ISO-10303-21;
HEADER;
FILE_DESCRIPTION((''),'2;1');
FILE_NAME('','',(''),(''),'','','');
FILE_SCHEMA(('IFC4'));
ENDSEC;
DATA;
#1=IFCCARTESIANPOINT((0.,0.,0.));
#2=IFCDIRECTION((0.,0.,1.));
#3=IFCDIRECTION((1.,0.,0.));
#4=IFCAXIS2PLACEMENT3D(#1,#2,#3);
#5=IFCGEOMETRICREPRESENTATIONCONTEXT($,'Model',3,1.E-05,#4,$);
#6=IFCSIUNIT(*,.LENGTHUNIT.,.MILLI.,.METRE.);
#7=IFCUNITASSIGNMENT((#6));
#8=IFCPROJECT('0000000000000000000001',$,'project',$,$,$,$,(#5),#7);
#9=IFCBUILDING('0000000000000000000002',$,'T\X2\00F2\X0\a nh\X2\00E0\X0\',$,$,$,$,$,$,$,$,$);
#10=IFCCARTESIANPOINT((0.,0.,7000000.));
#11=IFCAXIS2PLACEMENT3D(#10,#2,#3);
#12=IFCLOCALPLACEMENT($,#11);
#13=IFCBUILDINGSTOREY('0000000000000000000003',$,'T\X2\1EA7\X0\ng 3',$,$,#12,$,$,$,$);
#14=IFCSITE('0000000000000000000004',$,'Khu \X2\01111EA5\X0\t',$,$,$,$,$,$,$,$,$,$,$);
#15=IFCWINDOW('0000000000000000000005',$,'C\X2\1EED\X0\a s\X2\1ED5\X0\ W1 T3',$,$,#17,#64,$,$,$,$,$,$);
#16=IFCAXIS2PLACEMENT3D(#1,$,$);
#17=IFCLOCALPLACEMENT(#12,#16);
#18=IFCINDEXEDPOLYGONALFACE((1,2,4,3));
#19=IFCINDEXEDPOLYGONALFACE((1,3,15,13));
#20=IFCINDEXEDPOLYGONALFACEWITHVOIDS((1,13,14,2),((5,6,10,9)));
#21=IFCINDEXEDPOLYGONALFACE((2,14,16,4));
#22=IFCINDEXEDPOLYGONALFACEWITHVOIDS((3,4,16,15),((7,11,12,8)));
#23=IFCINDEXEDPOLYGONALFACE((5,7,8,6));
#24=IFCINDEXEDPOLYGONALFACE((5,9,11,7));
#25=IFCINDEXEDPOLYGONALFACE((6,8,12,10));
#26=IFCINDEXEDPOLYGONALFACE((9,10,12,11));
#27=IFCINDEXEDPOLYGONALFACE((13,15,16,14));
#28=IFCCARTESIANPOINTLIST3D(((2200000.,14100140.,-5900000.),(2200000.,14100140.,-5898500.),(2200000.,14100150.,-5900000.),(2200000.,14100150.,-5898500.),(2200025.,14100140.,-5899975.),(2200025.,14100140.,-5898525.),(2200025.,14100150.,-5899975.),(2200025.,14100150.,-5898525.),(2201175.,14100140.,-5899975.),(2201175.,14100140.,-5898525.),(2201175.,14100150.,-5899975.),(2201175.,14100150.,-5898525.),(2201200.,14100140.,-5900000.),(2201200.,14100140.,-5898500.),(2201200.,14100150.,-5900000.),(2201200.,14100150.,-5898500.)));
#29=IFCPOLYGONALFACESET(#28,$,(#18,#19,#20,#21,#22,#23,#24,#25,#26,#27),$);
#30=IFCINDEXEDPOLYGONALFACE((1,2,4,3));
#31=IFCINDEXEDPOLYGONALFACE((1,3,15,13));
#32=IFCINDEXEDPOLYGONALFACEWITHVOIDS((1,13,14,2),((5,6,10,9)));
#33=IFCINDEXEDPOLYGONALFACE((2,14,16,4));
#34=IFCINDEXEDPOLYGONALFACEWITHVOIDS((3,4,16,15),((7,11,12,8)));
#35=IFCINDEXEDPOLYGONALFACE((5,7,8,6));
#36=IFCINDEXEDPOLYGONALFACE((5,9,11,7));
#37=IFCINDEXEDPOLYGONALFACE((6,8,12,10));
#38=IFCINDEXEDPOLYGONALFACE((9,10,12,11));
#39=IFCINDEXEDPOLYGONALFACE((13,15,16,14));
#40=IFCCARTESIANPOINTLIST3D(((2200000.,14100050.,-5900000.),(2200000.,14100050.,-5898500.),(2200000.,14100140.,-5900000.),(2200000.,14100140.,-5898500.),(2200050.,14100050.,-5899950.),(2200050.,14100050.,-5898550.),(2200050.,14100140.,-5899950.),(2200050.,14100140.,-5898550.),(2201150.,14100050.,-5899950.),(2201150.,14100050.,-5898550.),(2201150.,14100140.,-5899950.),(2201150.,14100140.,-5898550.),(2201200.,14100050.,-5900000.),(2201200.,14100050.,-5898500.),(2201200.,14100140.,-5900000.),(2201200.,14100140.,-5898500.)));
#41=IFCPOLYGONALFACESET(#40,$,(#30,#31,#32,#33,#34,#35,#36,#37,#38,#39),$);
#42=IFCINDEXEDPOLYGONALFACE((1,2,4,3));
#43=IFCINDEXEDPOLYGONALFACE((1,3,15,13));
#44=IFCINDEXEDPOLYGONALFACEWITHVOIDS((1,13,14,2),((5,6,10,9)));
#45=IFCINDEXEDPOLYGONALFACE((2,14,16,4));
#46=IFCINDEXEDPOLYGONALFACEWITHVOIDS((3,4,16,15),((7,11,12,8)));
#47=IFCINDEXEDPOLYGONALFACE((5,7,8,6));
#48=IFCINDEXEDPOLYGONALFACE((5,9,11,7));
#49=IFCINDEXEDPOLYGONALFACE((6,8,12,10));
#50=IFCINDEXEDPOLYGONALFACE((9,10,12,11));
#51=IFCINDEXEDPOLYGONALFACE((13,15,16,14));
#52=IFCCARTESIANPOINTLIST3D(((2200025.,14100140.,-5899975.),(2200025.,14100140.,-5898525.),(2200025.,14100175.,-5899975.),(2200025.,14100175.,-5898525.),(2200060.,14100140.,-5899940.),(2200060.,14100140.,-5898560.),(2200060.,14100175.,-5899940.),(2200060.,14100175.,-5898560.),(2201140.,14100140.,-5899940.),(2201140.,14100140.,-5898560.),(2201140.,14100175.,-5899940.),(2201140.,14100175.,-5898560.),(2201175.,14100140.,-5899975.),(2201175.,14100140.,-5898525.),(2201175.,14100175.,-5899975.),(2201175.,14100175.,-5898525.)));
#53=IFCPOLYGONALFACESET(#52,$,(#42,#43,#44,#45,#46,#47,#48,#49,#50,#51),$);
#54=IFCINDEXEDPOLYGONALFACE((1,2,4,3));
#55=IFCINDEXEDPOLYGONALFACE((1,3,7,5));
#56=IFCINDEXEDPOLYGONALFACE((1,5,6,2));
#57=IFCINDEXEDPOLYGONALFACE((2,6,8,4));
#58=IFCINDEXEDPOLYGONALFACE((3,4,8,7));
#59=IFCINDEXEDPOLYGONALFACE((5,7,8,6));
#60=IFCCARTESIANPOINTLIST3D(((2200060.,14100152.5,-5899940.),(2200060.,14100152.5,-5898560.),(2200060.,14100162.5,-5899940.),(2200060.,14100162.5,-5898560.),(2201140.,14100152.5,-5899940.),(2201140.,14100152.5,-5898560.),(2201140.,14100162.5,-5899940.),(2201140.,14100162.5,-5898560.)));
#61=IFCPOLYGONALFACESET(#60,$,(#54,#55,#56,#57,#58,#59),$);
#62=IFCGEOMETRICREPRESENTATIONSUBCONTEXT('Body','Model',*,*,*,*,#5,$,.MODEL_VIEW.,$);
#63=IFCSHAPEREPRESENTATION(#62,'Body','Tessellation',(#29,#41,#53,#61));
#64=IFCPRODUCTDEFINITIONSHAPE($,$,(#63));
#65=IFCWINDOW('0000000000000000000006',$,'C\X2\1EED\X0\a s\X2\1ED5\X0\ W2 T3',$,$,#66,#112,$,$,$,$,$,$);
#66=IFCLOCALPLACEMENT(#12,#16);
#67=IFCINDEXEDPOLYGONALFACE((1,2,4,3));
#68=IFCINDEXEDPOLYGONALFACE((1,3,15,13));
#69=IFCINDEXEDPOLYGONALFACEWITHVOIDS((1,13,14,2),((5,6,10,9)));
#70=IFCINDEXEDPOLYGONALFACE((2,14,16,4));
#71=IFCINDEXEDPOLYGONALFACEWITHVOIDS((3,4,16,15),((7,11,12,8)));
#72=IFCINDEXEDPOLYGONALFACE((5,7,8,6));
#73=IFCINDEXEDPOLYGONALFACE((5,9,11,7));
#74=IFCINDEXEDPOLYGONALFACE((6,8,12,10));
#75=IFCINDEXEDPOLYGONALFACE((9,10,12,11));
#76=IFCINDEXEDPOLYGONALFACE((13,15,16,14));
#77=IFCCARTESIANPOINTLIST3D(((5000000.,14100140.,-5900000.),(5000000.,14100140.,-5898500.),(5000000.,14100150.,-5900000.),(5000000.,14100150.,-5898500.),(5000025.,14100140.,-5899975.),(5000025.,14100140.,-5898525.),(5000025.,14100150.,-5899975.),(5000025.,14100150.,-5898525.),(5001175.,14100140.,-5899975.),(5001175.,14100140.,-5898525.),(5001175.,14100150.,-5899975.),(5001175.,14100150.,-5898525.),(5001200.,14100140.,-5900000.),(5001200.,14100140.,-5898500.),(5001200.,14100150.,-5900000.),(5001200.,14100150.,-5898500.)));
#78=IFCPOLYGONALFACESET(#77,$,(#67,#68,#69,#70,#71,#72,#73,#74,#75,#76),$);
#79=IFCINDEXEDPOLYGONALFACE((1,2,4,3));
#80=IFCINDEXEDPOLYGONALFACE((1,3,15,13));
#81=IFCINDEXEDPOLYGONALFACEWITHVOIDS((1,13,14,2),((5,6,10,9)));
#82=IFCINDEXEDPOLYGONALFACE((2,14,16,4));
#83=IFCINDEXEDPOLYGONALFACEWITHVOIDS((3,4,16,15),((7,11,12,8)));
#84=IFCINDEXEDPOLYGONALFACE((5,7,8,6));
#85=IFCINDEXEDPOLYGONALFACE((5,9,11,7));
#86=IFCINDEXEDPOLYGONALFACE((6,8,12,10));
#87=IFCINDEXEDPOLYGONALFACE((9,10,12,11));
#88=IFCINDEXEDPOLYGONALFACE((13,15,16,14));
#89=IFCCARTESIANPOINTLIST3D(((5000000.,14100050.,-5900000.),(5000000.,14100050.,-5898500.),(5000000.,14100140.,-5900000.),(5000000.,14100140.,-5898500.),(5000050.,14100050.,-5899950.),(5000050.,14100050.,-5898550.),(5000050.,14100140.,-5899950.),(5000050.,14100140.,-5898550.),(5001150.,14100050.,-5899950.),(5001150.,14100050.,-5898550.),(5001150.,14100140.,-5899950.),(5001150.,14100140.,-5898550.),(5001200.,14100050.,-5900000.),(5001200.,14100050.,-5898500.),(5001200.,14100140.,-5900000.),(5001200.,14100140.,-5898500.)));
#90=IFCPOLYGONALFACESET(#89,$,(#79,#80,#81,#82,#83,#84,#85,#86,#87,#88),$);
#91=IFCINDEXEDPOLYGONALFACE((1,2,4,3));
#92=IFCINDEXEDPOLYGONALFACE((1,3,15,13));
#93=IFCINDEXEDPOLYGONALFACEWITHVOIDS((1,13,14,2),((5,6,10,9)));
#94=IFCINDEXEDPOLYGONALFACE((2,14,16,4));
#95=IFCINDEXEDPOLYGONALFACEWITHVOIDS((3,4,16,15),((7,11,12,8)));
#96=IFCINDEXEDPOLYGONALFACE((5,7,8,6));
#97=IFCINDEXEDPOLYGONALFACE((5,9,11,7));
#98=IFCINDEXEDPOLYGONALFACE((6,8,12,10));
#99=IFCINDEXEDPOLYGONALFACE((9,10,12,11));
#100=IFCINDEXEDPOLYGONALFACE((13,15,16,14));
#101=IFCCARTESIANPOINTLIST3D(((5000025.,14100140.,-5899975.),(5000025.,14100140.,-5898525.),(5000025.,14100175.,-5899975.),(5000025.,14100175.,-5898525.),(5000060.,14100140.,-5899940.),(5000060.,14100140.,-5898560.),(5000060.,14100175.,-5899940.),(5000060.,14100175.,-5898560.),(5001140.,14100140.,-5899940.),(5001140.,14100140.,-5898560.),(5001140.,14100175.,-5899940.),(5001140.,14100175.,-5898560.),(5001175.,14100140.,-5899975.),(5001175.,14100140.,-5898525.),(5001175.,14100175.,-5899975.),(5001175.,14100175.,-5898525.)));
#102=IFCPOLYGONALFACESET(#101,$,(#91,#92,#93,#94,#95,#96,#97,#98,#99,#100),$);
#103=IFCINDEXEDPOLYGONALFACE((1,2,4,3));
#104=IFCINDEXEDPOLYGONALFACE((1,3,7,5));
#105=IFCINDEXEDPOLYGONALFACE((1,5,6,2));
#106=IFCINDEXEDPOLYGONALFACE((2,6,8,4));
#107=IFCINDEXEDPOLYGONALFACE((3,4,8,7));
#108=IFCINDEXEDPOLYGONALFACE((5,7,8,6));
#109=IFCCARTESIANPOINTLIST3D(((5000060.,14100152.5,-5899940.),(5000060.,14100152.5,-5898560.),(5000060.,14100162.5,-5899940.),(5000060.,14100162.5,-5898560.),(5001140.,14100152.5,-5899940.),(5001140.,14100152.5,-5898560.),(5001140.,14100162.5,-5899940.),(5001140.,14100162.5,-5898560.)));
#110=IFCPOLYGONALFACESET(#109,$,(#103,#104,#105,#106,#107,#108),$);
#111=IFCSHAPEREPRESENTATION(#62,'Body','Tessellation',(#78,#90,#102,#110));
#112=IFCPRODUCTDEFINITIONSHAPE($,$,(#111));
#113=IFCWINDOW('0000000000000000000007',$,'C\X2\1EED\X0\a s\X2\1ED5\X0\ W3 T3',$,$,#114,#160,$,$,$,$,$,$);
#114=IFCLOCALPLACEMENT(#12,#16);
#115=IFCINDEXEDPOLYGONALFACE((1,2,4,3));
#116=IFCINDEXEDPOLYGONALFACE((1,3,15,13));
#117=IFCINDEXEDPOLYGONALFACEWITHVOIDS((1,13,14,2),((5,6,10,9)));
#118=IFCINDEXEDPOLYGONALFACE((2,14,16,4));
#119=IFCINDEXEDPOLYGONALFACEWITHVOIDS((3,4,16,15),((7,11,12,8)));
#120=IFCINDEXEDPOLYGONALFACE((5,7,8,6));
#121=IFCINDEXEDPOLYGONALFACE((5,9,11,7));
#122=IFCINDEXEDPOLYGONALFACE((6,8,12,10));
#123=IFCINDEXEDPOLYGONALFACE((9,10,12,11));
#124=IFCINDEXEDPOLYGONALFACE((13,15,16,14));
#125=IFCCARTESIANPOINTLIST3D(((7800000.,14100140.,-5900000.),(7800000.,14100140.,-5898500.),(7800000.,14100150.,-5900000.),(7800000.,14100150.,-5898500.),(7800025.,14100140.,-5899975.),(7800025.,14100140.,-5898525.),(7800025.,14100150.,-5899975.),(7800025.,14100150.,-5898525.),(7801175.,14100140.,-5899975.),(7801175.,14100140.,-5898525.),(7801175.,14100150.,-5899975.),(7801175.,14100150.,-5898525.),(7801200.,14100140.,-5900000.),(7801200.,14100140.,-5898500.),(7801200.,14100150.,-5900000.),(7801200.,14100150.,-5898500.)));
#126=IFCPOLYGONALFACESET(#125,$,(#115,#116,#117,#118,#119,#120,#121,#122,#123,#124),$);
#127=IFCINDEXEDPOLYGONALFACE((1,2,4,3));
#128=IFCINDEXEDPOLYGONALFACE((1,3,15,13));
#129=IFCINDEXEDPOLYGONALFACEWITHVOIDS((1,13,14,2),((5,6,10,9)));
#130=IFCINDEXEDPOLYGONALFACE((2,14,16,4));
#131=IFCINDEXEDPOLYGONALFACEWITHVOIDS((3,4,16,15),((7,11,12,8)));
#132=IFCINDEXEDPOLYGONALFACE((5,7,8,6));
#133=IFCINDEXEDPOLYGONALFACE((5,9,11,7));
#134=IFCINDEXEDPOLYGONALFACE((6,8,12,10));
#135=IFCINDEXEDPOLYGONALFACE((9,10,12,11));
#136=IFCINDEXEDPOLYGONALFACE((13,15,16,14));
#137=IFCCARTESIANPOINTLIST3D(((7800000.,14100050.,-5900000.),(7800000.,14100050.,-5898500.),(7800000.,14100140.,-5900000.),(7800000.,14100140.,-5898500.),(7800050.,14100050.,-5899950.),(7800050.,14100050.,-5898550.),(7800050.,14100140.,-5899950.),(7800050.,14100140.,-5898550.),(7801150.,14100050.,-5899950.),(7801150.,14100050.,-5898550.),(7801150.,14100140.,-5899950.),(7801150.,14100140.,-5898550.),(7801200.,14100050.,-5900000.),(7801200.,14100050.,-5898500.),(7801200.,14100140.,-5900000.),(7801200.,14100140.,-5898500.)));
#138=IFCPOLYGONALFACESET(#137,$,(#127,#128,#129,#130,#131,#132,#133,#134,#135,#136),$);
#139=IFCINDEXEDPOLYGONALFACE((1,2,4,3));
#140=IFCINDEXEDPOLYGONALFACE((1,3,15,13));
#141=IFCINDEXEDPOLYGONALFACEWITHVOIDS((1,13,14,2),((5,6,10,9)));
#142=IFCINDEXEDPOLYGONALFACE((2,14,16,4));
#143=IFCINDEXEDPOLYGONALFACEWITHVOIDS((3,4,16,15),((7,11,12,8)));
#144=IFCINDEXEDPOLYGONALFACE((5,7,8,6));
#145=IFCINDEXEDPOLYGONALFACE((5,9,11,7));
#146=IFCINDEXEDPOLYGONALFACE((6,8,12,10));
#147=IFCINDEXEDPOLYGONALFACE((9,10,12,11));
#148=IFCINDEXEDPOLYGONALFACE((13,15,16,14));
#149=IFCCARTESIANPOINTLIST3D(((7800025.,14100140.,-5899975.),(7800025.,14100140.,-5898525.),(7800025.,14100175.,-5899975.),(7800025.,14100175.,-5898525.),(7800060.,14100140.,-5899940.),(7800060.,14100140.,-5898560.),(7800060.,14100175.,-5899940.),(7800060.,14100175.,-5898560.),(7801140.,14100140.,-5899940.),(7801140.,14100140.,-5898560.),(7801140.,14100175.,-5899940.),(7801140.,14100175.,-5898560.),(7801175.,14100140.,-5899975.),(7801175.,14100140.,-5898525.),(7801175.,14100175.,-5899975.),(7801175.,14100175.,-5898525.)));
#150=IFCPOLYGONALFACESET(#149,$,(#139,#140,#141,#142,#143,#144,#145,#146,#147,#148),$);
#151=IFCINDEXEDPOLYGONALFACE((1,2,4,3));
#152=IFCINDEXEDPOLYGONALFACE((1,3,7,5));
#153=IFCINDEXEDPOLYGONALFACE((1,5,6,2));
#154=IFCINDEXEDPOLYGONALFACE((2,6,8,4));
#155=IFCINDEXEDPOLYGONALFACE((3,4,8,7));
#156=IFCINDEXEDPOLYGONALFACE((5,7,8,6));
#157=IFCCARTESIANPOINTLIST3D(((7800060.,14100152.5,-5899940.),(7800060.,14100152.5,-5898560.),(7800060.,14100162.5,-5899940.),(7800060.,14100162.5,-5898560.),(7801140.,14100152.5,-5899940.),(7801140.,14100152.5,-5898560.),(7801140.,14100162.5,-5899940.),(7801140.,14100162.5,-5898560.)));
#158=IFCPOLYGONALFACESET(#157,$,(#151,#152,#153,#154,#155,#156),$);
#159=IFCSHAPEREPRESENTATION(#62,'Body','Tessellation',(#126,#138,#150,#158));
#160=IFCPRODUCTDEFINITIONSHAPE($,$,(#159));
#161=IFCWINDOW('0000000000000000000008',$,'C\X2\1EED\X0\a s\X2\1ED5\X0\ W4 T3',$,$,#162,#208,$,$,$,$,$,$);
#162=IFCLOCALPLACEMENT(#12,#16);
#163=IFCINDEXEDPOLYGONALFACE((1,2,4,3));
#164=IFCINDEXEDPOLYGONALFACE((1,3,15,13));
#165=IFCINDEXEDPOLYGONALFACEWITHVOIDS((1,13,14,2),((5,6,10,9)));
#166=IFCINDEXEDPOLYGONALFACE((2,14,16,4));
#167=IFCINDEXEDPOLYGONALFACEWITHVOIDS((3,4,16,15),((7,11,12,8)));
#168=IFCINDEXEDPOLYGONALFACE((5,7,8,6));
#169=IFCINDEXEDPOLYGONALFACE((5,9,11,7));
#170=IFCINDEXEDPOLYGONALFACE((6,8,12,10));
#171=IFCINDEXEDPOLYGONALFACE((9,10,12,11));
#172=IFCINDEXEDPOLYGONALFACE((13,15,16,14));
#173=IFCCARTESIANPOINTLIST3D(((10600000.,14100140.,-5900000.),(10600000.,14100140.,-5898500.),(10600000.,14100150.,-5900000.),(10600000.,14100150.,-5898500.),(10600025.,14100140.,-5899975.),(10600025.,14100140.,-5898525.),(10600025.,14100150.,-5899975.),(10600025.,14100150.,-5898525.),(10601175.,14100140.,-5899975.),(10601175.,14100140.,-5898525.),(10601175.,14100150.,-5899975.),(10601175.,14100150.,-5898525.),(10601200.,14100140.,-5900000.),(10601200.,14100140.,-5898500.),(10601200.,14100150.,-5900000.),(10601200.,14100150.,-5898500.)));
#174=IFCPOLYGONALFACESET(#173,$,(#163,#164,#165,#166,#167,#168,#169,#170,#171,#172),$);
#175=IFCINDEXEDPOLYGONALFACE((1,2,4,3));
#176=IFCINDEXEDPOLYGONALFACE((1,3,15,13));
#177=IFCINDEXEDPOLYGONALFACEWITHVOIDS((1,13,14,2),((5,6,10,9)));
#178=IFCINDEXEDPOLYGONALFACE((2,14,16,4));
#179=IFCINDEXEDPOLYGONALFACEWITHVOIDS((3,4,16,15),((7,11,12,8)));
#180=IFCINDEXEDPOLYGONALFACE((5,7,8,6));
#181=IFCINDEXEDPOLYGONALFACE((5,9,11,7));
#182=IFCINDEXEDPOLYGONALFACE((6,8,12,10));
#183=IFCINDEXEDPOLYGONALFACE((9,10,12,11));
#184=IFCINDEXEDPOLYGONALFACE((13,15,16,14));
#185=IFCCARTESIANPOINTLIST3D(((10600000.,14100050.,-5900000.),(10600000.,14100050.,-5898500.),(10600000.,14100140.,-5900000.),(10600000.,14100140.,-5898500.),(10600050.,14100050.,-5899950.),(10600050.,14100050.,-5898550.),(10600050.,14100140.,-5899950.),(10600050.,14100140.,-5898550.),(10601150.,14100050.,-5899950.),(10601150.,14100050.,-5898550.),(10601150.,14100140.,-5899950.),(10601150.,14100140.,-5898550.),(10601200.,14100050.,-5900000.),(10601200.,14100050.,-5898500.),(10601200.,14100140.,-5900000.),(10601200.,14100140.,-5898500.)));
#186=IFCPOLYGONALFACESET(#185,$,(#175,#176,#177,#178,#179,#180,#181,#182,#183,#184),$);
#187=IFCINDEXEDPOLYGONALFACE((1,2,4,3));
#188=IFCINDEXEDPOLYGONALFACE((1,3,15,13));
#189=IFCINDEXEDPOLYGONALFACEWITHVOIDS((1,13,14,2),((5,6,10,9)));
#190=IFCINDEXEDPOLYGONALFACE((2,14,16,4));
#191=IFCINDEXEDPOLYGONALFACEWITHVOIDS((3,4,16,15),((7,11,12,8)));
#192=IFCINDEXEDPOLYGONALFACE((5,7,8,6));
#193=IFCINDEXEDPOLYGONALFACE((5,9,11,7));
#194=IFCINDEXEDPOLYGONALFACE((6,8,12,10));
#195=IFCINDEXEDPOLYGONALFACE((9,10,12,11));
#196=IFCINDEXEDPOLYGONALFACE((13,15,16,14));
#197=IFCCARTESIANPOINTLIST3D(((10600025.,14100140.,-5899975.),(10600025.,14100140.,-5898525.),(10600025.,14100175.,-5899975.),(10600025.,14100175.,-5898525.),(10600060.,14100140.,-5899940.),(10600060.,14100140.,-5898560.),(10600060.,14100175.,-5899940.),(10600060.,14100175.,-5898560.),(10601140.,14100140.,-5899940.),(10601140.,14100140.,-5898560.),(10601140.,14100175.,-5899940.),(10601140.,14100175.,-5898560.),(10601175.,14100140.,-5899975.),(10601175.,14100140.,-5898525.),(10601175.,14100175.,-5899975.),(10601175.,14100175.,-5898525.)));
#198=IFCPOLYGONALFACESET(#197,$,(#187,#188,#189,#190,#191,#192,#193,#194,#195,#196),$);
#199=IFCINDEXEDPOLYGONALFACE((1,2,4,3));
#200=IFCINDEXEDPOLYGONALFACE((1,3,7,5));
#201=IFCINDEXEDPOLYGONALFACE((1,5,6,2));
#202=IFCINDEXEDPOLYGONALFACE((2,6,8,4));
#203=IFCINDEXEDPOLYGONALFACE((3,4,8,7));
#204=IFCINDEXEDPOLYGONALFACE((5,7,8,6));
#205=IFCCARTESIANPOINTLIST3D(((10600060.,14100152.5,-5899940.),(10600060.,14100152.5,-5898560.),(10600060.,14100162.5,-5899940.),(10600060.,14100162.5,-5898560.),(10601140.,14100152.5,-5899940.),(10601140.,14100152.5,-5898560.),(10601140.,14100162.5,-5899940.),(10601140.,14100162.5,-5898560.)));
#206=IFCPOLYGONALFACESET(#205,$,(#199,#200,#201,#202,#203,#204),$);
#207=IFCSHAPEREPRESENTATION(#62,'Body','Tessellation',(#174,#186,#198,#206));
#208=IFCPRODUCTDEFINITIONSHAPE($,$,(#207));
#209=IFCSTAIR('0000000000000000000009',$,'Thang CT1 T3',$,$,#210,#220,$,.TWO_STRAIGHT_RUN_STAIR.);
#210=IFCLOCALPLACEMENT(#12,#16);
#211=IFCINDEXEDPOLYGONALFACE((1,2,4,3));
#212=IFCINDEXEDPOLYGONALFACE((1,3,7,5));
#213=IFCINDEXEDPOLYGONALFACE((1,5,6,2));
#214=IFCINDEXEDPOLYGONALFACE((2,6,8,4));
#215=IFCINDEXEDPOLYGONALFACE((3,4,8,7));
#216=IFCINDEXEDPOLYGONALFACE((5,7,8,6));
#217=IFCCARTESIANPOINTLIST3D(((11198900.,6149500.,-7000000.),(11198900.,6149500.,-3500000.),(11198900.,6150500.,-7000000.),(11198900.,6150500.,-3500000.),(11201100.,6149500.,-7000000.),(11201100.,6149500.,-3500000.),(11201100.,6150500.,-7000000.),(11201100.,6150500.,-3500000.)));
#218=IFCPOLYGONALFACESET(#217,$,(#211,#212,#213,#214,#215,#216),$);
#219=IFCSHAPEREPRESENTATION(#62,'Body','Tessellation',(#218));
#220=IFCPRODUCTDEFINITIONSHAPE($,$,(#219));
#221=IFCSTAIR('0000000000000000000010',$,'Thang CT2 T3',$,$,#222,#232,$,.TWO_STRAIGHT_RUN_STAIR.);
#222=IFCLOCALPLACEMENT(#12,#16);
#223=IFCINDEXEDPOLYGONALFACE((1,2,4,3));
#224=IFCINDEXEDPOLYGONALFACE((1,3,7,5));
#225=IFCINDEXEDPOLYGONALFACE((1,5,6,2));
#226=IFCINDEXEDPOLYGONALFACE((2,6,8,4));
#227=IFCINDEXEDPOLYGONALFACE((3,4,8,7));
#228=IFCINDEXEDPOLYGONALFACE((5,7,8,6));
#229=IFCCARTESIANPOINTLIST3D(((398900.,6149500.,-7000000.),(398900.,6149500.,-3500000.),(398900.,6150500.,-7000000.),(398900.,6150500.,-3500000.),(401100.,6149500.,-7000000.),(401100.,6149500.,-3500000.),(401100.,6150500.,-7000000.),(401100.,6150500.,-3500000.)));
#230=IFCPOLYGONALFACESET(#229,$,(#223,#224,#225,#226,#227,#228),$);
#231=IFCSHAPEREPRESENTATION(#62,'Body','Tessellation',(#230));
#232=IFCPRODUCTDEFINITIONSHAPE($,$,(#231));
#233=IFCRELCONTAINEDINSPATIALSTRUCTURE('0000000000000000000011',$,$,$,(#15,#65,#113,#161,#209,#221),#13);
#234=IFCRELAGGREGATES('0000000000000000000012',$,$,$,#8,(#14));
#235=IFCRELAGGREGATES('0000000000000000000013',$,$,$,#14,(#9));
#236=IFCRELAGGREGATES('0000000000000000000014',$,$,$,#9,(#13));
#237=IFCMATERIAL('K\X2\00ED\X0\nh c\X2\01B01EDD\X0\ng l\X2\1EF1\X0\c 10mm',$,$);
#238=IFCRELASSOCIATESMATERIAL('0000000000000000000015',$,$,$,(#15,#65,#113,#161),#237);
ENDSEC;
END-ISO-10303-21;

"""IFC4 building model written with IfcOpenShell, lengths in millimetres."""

from ifc_helpers import new_model, entity, si_unit, frame, origin_with_axes, place, context, subcontext, project, spatial, line, indexed_curve, outline, extrude, material, element, save


model = new_model("IFC4")

# Units and contexts
model_context = context("Model", 3, precision=1e-05, world=origin_with_axes())
body_context = subcontext(model_context, "Body", "Model", "MODEL_VIEW")
ifc_project = project(units=[si_unit("LENGTHUNIT", "METRE", prefix="MILLI")], contexts=[model_context])

# Site, building, storey
site = spatial("IfcSite", under=ifc_project, Name="Khu đất")
building = spatial("IfcBuilding", under=site, Name="Tòa nhà")
storey_placement = place(None, frame((0.0, 0.0, 7000000.0), z_axis=(0.0, 0.0, 1.0), x_axis=(1.0, 0.0, 0.0)))
storey = spatial("IfcBuildingStorey", under=building, at=storey_placement, Name="Tầng 3")

# Windows
ifc_material_1 = material(Name="Kính cường lực 10mm")
for number, where, z_axis, x_axis, name in (
    (1, (2200000.0, 14100000.0, -5900000.0), (0.0, 0.0, 1.0), (1.0, 0.0, 0.0), "Cửa sổ W1 T3"),
    (2, (5000000.0, 14100000.0, -5900000.0), (0.0, 0.0, 1.0), (1.0, 0.0, 0.0), "Cửa sổ W2 T3"),
    (3, (7800000.0, 14100000.0, -5900000.0), (0.0, 0.0, 1.0), (1.0, 0.0, 0.0), "Cửa sổ W3 T3"),
    (4, (10600000.0, 14100000.0, -5900000.0), (0.0, 0.0, 1.0), (1.0, 0.0, 0.0), "Cửa sổ W4 T3"),
):
    element("IfcWindow", number, at=place(storey_placement, frame(where, z_axis=z_axis, x_axis=x_axis)), inside=storey, material=ifc_material_1, Name=name, context=body_context, shape_type="SolidModel", body=[
        extrude(outline(indexed_curve([(0.0, 0.0), (1200.0, 0.0), (1200.0, 1500.0), (0.0, 1500.0)], segments=[line(1, 2, 3, 4, 1)]), holes=[indexed_curve([(25.0, 25.0), (1175.0, 25.0), (1175.0, 1475.0), (25.0, 1475.0)], segments=[line(1, 2, 3, 4, 1)])]), frame((0.0, 140.0, 0.0), z_axis=(0.0, -1.0, 0.0), x_axis=(1.0, 0.0, 0.0)), (0.0, 0.0, -1.0), 10.0),
        extrude(outline(indexed_curve([(0.0, 0.0), (1200.0, 0.0), (1200.0, 1500.0), (0.0, 1500.0)], segments=[line(1, 2, 3, 4, 1)]), holes=[indexed_curve([(50.0, 50.0), (1150.0, 50.0), (1150.0, 1450.0), (50.0, 1450.0)], segments=[line(1, 2, 3, 4, 1)])]), frame((0.0, 50.0, 0.0), z_axis=(0.0, -1.0, 0.0), x_axis=(1.0, 0.0, 0.0)), (0.0, 0.0, -1.0), 90.0),
        extrude(outline(indexed_curve([(0.0, 0.0), (1150.0, 0.0), (1150.0, 1450.0), (0.0, 1450.0)], segments=[line(1, 2, 3, 4, 1)]), holes=[indexed_curve([(35.0, 35.0), (1115.0, 35.0), (1115.0, 1415.0), (35.0, 1415.0)], segments=[line(1, 2, 3, 4, 1)])]), frame((25.0, 140.0, 25.0), z_axis=(0.0, -1.0, 0.0), x_axis=(1.0, 0.0, 0.0)), (0.0, 0.0, -1.0), 35.0),
        extrude(outline(indexed_curve([(35.0, 35.0), (1115.0, 35.0), (1115.0, 1415.0), (35.0, 1415.0)], segments=[line(1, 2, 3, 4, 1)])), frame((25.0, 152.5, 25.0), z_axis=(0.0, -1.0, 0.0), x_axis=(1.0, 0.0, 0.0)), (0.0, 0.0, -1.0), 10.0),
    ])

# Stairs
for number, where, z_axis, x_axis, name in (
    (5, (11200000.0, 6150000.0, -7000000.0), (0.0, 0.0, 1.0), (1.0, 0.0, 0.0), "Thang CT1 T3"),
    (6, (400000.0, 6150000.0, -7000000.0), (0.0, 0.0, 1.0), (1.0, 0.0, 0.0), "Thang CT2 T3"),
):
    element("IfcStair", number, at=place(storey_placement, frame(where, z_axis=z_axis, x_axis=x_axis)), inside=storey, Name=name, PredefinedType="TWO_STRAIGHT_RUN_STAIR", context=body_context, shape_type="SweptSolid", body=[
        extrude(entity("IfcRectangleProfileDef", None, None, None, 2200.0, 1000.0), origin_with_axes(), (0.0, 0.0, 1.0), 3500000.0),
    ])

save(model, "model.ifc")
